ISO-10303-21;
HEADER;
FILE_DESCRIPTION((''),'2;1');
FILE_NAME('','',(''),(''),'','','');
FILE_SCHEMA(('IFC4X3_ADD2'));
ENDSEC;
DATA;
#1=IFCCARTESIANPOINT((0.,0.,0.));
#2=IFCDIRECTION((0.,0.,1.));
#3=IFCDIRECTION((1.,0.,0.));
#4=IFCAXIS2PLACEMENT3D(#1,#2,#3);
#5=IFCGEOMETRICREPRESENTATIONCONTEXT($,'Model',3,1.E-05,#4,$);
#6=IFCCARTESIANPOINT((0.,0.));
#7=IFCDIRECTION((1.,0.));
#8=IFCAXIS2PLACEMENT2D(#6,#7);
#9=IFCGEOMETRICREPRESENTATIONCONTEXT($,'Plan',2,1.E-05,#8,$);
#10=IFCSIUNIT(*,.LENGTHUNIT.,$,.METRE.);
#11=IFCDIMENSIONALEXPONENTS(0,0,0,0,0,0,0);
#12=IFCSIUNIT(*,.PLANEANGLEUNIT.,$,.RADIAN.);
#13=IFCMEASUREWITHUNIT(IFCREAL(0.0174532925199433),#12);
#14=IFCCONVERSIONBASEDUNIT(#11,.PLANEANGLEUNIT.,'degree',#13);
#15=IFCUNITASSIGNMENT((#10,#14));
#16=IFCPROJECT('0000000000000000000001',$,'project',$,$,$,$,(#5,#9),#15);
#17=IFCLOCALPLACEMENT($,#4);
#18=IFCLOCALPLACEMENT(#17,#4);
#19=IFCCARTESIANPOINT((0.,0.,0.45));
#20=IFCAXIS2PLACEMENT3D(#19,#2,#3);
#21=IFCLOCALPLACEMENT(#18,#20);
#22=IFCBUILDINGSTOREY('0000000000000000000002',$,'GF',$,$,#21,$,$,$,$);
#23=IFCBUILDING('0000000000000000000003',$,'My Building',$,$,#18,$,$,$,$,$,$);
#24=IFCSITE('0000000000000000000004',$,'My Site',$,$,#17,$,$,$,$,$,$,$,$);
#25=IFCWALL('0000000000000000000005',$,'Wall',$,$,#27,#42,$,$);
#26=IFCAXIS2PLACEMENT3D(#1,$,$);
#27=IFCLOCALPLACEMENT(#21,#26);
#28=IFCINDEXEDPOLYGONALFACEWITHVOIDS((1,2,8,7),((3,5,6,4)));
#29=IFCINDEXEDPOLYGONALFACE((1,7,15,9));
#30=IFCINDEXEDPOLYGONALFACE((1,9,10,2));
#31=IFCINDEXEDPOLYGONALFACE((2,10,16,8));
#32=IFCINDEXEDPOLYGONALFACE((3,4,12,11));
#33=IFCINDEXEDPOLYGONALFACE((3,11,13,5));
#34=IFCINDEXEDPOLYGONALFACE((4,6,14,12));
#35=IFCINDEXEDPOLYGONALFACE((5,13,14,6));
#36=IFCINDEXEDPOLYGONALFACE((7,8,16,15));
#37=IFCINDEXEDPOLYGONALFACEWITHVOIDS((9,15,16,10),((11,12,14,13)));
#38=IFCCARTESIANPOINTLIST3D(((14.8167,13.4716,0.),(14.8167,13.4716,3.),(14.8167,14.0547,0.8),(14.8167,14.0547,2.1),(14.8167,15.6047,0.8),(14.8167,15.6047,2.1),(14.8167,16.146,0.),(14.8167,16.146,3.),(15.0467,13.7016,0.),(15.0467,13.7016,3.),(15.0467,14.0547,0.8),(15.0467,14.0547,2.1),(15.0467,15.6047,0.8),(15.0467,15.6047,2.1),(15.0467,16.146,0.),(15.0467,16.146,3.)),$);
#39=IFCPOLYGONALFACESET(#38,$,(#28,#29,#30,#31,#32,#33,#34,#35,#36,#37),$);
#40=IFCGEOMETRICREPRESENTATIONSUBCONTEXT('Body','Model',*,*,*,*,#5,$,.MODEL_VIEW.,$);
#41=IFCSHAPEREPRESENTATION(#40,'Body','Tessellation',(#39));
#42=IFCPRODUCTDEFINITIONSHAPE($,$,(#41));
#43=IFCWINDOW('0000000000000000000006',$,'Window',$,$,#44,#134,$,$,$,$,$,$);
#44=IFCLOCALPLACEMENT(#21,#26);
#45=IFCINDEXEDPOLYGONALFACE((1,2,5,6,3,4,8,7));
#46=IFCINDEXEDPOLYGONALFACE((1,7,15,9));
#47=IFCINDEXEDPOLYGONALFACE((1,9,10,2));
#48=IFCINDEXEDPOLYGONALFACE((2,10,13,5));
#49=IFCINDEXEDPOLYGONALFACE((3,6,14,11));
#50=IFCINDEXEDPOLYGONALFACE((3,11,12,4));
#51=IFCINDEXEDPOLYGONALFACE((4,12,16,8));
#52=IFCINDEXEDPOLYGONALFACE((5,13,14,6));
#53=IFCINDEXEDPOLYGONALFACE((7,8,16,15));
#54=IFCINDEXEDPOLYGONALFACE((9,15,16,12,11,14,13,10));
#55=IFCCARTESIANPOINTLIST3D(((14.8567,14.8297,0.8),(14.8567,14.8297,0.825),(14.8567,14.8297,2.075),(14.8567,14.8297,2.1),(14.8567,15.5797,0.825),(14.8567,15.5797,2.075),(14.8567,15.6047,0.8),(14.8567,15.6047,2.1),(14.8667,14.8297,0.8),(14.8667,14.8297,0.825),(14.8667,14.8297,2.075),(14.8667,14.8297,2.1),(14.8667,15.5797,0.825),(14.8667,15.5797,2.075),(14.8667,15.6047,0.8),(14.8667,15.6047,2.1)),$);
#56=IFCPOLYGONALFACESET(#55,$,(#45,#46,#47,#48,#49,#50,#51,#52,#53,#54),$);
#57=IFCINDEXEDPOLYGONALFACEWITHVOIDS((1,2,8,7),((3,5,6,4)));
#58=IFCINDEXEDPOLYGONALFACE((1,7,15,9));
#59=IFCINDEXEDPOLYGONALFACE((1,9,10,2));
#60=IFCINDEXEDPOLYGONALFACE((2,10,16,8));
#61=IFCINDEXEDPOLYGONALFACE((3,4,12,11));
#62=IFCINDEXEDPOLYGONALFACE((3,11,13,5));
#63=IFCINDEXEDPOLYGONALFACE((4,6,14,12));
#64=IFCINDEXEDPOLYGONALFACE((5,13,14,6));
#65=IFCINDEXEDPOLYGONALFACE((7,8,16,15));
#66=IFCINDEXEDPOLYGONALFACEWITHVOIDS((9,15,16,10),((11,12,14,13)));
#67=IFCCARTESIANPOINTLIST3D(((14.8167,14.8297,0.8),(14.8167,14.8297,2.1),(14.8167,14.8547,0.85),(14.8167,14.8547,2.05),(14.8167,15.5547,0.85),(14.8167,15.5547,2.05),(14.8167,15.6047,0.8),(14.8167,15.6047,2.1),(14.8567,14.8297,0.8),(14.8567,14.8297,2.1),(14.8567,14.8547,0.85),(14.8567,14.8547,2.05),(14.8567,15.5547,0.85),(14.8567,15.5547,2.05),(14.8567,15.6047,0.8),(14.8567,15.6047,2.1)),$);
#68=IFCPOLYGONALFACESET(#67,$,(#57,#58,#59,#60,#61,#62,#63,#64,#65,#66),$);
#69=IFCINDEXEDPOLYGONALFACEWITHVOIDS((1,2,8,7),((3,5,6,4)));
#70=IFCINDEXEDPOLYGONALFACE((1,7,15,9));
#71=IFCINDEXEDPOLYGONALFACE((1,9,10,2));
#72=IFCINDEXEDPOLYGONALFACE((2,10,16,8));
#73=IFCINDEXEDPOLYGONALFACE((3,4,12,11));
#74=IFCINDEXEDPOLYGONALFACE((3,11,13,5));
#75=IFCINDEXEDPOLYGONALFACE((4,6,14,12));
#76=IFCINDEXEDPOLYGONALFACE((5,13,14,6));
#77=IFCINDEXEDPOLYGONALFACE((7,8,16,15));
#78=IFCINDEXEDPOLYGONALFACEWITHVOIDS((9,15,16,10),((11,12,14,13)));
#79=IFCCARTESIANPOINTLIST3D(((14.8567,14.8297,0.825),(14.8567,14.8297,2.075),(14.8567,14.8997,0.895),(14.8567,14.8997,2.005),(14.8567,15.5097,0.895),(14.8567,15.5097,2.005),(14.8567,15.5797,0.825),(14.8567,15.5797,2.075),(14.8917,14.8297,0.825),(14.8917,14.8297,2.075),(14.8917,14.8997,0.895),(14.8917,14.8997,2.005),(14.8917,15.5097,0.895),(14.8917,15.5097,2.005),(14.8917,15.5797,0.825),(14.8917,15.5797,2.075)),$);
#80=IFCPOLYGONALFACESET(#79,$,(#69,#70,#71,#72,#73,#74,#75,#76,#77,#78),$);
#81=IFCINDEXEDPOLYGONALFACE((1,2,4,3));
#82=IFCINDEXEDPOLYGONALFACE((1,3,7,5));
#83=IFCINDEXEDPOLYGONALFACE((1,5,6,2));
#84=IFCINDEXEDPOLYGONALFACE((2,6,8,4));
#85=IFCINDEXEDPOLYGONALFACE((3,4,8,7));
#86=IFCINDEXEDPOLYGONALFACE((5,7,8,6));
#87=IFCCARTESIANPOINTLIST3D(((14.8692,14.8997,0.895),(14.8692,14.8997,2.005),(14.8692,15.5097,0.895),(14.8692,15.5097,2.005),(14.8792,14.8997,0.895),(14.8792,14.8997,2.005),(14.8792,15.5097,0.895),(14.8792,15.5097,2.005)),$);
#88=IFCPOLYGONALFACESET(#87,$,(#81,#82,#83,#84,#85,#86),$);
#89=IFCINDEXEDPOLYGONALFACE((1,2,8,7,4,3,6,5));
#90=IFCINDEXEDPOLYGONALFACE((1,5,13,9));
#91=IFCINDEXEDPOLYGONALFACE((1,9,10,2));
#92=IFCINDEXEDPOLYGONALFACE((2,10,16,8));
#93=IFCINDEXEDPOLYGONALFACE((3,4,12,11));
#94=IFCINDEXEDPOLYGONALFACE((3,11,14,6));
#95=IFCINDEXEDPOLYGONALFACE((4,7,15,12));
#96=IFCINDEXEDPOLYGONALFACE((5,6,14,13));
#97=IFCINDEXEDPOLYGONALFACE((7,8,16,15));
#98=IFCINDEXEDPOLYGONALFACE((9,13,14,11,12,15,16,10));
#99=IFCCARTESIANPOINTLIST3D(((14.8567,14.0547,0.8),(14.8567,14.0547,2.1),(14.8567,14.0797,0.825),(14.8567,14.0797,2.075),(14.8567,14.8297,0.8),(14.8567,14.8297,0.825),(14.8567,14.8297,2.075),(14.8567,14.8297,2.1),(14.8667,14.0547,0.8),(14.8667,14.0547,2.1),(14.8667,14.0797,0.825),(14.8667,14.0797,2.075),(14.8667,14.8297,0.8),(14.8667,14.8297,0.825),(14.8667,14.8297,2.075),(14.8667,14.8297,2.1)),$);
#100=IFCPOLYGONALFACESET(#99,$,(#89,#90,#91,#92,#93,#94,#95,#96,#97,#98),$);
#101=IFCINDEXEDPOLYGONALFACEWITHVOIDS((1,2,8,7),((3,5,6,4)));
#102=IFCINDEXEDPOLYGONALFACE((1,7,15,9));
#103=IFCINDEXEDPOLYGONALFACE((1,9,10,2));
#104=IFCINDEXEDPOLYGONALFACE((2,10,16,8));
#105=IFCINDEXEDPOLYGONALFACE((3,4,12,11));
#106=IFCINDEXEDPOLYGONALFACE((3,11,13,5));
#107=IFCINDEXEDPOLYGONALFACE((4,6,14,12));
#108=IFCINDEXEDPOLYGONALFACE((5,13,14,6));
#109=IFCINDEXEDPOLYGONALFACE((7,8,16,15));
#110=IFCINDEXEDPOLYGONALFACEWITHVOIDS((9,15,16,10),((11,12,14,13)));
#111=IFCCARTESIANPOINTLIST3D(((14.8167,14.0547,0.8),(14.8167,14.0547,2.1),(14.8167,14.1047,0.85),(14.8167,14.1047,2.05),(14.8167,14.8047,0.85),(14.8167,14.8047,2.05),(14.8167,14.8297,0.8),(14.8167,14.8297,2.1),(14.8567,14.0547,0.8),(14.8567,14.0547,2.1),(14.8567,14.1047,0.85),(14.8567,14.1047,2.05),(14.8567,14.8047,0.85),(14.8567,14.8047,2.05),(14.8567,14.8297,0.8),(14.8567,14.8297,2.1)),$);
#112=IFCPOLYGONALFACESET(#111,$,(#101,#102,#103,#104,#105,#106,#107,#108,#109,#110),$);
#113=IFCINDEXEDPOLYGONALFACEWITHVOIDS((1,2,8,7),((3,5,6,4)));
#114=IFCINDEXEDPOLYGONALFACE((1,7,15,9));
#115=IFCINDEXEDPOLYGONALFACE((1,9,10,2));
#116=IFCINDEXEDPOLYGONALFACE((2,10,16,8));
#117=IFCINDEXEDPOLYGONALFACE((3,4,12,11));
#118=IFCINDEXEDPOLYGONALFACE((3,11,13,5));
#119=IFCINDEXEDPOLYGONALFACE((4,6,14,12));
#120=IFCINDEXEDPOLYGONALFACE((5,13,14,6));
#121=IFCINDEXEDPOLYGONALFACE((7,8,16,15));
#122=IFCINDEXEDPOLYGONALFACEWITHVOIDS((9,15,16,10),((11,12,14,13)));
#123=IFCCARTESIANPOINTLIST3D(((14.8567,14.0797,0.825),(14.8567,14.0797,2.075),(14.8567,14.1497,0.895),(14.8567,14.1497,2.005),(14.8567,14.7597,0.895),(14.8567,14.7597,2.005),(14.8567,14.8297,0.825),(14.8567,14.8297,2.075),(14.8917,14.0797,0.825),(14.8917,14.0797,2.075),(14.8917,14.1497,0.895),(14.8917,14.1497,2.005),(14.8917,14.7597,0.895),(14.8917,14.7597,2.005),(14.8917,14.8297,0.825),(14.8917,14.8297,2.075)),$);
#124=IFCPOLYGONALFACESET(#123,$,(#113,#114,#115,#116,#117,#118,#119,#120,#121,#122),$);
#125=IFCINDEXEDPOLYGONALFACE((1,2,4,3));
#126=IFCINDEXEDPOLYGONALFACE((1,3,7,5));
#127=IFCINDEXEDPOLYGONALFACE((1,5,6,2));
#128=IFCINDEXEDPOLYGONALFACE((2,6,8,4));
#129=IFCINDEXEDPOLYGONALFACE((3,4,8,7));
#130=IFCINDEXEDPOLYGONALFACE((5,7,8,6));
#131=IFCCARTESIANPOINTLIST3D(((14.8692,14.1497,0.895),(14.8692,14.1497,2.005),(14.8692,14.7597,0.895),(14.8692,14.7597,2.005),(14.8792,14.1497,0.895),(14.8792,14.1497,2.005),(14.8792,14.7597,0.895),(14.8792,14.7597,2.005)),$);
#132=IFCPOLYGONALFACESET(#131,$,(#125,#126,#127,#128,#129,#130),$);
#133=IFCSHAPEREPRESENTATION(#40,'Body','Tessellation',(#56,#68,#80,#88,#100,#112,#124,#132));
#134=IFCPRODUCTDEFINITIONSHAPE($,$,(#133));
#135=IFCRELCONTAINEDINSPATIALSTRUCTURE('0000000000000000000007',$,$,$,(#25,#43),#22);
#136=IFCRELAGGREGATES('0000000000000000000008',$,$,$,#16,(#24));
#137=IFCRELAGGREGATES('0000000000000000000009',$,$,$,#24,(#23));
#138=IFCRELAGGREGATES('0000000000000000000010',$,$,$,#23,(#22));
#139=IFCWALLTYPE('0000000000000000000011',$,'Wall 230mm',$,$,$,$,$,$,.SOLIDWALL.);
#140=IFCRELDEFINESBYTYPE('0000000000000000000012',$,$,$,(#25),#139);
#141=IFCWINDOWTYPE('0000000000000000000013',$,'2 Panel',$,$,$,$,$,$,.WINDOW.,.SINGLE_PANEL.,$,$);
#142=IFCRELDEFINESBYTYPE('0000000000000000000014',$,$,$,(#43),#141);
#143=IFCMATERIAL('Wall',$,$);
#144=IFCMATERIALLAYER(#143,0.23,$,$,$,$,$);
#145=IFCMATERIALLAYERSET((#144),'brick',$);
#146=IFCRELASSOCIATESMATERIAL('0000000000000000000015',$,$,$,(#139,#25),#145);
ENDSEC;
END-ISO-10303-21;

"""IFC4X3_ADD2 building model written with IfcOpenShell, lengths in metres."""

from ifc_helpers import new_model, entity, si_unit, converted_unit, frame, origin_with_axes, origin_2d_with_axis, place, context, subcontext, project, spatial, line, indexed_curve, outline, extrude, clip, halfspace, shape, source, transform, mapped, material, layer, layer_set, layer_usage, type_object, type_shapes, element, fill, save


model = new_model("IFC4X3_ADD2")

# Units and contexts
model_context = context("Model", 3, precision=1e-05, world=origin_with_axes())
plan_context = context("Plan", 2, precision=1e-05, world=origin_2d_with_axis())
body_context_1 = subcontext(model_context, "Body", "Model", "MODEL_VIEW")
body_context_2 = subcontext(plan_context, "Body", "Plan", "PLAN_VIEW")
ifc_project = project(units=[si_unit("LENGTHUNIT", "METRE"), converted_unit("PLANEANGLEUNIT", "degree", entity("IfcReal", 0.0174532925199433), si_unit("PLANEANGLEUNIT", "RADIAN"), dimensions=[0, 0, 0, 0, 0, 0, 0])], contexts=[model_context, plan_context])

# Site, building, storey
site_placement = place(None, origin_with_axes())
site = spatial("IfcSite", under=ifc_project, at=site_placement, Name="My Site")
building_placement = place(site_placement, origin_with_axes())
building = spatial("IfcBuilding", under=site, at=building_placement, Name="My Building")
storey_placement = place(building_placement, frame((0.0, 0.0, 0.45), z_axis=(0.0, 0.0, 1.0), x_axis=(1.0, 0.0, 0.0)))
storey = spatial("IfcBuildingStorey", under=building, at=storey_placement, Name="GF")

# Shared definitions
ifc_material_1 = material(Name="Wall")
ifc_layer = layer(ifc_material_1, 0.23)
ifc_layer_set = layer_set([ifc_layer], Name="brick")
wall_type = type_object("IfcWallType", Name="Wall 230mm", PredefinedType="SOLIDWALL", material=ifc_layer_set)

# Wall, opening, window
ifc_layer_usage_1 = layer_usage(ifc_layer_set, "AXIS2", "POSITIVE", 0.0)
wall_1_placement = place(storey_placement, frame((15.0467, 13.1463, 0.0), z_axis=(0.0, 0.0, 1.0), x_axis=(0.0, 1.0, 0.0)))
wall_1 = element("IfcWall", 1, at=wall_1_placement, inside=storey, type_object=wall_type, material=ifc_layer_usage_1, Name="Wall", context=body_context_1, shape_type="Clipping", body=[
    clip(extrude(outline(indexed_curve([(0.0, 0.0), (0.0, 0.23), (2.9997, 0.23), (2.9997, 0.0), (0.0, 0.0)], self_intersect=False)), origin_with_axes(), (0.0, 0.0, 1.0), 3.0), halfspace(frame((0.5553, 0.0, -0.45), z_axis=(-0.689998, -0.689999, 0.0), x_axis=(-0.707107, 0.707107, 0.0)), False)),
])
shared_shape_1 = source(origin_with_axes(), body_context_1, "Body", "SweptSolid", [
    extrude(outline(indexed_curve([(0.0, 0.0), (1.55, 0.0), (1.55, 1.3), (0.0, 1.3)], segments=[line(1, 2, 3, 4, 1)])), frame((0.0, -0.6, 0.0), z_axis=(0.0, -1.0, 0.0), x_axis=(1.0, 0.0, 0.0)), (0.0, 0.0, -1.0), 1.2),
])
opening_1_placement = place(wall_1_placement, frame((2.4583, 0.28, 0.8), z_axis=(0.0, 0.0, 1.0), x_axis=(-1.0, 0.0, 0.0)))
opening_1 = element("IfcOpeningElement", 2, at=opening_1_placement, cuts=wall_1, PredefinedType="OPENING", context=body_context_1, shape_type="MappedRepresentation", body=[
    mapped(shared_shape_1, transform((0.0, 0.0, 0.0), x_axis=(1.0, 0.0, 0.0), y_axis=(0.0, 1.0, 0.0), z_axis=(0.0, 0.0, 1.0), scale=1.0)),
])
window_type_1 = type_object("IfcWindowType", Name="2 Panel", PartitioningType="SINGLE_PANEL", PredefinedType="WINDOW")
shared_shape_2 = source(origin_with_axes(), body_context_1, "Body", "SweptSolid", [
    extrude(outline(indexed_curve([(0.775, 0.0), (0.0, 0.0), (0.0, 1.3), (0.775, 1.3), (0.775, 1.275), (0.025, 1.275), (0.025, 0.025), (0.775, 0.025)], segments=[line(1, 2, 3, 4, 5, 6, 7, 8, 1)])), frame((0.0, 0.09, 0.0), z_axis=(0.0, -1.0, 0.0), x_axis=(1.0, 0.0, 0.0)), (0.0, 0.0, -1.0), 0.01),
    extrude(outline(indexed_curve([(0.0, 0.0), (0.775, 0.0), (0.775, 1.3), (0.0, 1.3)], segments=[line(1, 2, 3, 4, 1)]), holes=[indexed_curve([(0.05, 0.05), (0.75, 0.05), (0.75, 1.25), (0.05, 1.25)], segments=[line(1, 2, 3, 4, 1)])]), frame((0.0, 0.05, 0.0), z_axis=(0.0, -1.0, 0.0), x_axis=(1.0, 0.0, 0.0)), (0.0, 0.0, -1.0), 0.04),
    extrude(outline(indexed_curve([(0.0, 0.0), (0.75, 0.0), (0.75, 1.25), (0.0, 1.25)], segments=[line(1, 2, 3, 4, 1)]), holes=[indexed_curve([(0.07, 0.07), (0.68, 0.07), (0.68, 1.18), (0.07, 1.18)], segments=[line(1, 2, 3, 4, 1)])]), frame((0.025, 0.09, 0.025), z_axis=(0.0, -1.0, 0.0), x_axis=(1.0, 0.0, 0.0)), (0.0, 0.0, -1.0), 0.035),
    extrude(outline(indexed_curve([(0.07, 0.07), (0.68, 0.07), (0.68, 1.18), (0.07, 1.18)], segments=[line(1, 2, 3, 4, 1)])), frame((0.025, 0.1025, 0.025), z_axis=(0.0, -1.0, 0.0), x_axis=(1.0, 0.0, 0.0)), (0.0, 0.0, -1.0), 0.01),
    extrude(outline(indexed_curve([(0.0, 1.3), (0.775, 1.3), (0.775, 0.0), (0.0, 0.0), (0.0, 0.025), (0.75, 0.025), (0.75, 1.275), (0.0, 1.275)], segments=[line(1, 2, 3, 4, 5, 6, 7, 8, 1)])), frame((0.775, 0.09, 0.0), z_axis=(0.0, -1.0, 0.0), x_axis=(1.0, 0.0, 0.0)), (0.0, 0.0, -1.0), 0.01),
    extrude(outline(indexed_curve([(0.0, 0.0), (0.775, 0.0), (0.775, 1.3), (0.0, 1.3)], segments=[line(1, 2, 3, 4, 1)]), holes=[indexed_curve([(0.025, 0.05), (0.725, 0.05), (0.725, 1.25), (0.025, 1.25)], segments=[line(1, 2, 3, 4, 1)])]), frame((0.775, 0.05, 0.0), z_axis=(0.0, -1.0, 0.0), x_axis=(1.0, 0.0, 0.0)), (0.0, 0.0, -1.0), 0.04),
    extrude(outline(indexed_curve([(0.0, 0.0), (0.75, 0.0), (0.75, 1.25), (0.0, 1.25)], segments=[line(1, 2, 3, 4, 1)]), holes=[indexed_curve([(0.07, 0.07), (0.68, 0.07), (0.68, 1.18), (0.07, 1.18)], segments=[line(1, 2, 3, 4, 1)])]), frame((0.775, 0.09, 0.025), z_axis=(0.0, -1.0, 0.0), x_axis=(1.0, 0.0, 0.0)), (0.0, 0.0, -1.0), 0.035),
    extrude(outline(indexed_curve([(0.07, 0.07), (0.68, 0.07), (0.68, 1.18), (0.07, 1.18)], segments=[line(1, 2, 3, 4, 1)])), frame((0.775, 0.1025, 0.025), z_axis=(0.0, -1.0, 0.0), x_axis=(1.0, 0.0, 0.0)), (0.0, 0.0, -1.0), 0.01),
])
shared_shape_3 = source(origin_with_axes(), body_context_2, "Body", "Curve2D", [
    entity("IfcIndexedPolyCurve", entity("IfcCartesianPointList2D", [[0.05, 0.05], [0.75, 0.05]])),
    entity("IfcIndexedPolyCurve", entity("IfcCartesianPointList2D", [[0.0, 0.1], [0.025, 0.1], [0.025, 0.09], [0.05, 0.09], [0.05, 0.05], [0.0, 0.05]]), [entity("IfcLineIndex", [1, 2, 3, 4, 5, 6, 1])]),
    entity("IfcIndexedPolyCurve", entity("IfcCartesianPointList2D", [[0.775, 0.1], [0.775, 0.1], [0.775, 0.09], [0.75, 0.09], [0.75, 0.05], [0.775, 0.05]])),
    entity("IfcIndexedPolyCurve", entity("IfcCartesianPointList2D", [[0.025, 0.09], [0.095, 0.09], [0.095, 0.125], [0.025, 0.125]]), [entity("IfcLineIndex", [1, 2, 3, 4, 1])]),
    entity("IfcIndexedPolyCurve", entity("IfcCartesianPointList2D", [[0.775, 0.09], [0.705, 0.09], [0.705, 0.125], [0.775, 0.125]]), [entity("IfcLineIndex", [1, 2, 3, 4, 1])]),
    entity("IfcIndexedPolyCurve", entity("IfcCartesianPointList2D", [[0.095, 0.09], [0.705, 0.09]])),
    entity("IfcIndexedPolyCurve", entity("IfcCartesianPointList2D", [[0.095, 0.125], [0.705, 0.125]])),
    entity("IfcIndexedPolyCurve", entity("IfcCartesianPointList2D", [[0.095, 0.1075], [0.705, 0.1075]])),
    entity("IfcIndexedPolyCurve", entity("IfcCartesianPointList2D", [[0.8, 0.05], [1.5, 0.05]])),
    entity("IfcIndexedPolyCurve", entity("IfcCartesianPointList2D", [[0.775, 0.1], [0.775, 0.1], [0.775, 0.09], [0.8, 0.09], [0.8, 0.05], [0.775, 0.05]])),
    entity("IfcIndexedPolyCurve", entity("IfcCartesianPointList2D", [[1.55, 0.1], [1.525, 0.1], [1.525, 0.09], [1.5, 0.09], [1.5, 0.05], [1.55, 0.05]]), [entity("IfcLineIndex", [1, 2, 3, 4, 5, 6, 1])]),
    entity("IfcIndexedPolyCurve", entity("IfcCartesianPointList2D", [[0.775, 0.09], [0.845, 0.09], [0.845, 0.125], [0.775, 0.125]]), [entity("IfcLineIndex", [1, 2, 3, 4, 1])]),
    entity("IfcIndexedPolyCurve", entity("IfcCartesianPointList2D", [[1.525, 0.09], [1.455, 0.09], [1.455, 0.125], [1.525, 0.125]]), [entity("IfcLineIndex", [1, 2, 3, 4, 1])]),
    entity("IfcIndexedPolyCurve", entity("IfcCartesianPointList2D", [[0.845, 0.09], [1.455, 0.09]])),
    entity("IfcIndexedPolyCurve", entity("IfcCartesianPointList2D", [[0.845, 0.125], [1.455, 0.125]])),
    entity("IfcIndexedPolyCurve", entity("IfcCartesianPointList2D", [[0.845, 0.1075], [1.455, 0.1075]])),
])
type_shapes(window_type_1, [shared_shape_2, shared_shape_3])
window_1_placement = place(opening_1_placement, frame((0.0, 0.0, 0.0), z_axis=(0.0, 0.0, 1.0), x_axis=(1.0, 0.0, 0.0)))
window_1 = element("IfcWindow", 3, at=window_1_placement, inside=storey, type_object=window_type_1, Name="Window", shapes=[
    shape(body_context_1, "Body", "MappedRepresentation", [mapped(shared_shape_2, transform((0.0, 0.0, 0.0), x_axis=(1.0, 0.0, 0.0), y_axis=(0.0, 1.0, 0.0), z_axis=(0.0, 0.0, 1.0), scale=1.0))]),
    shape(body_context_2, "Body", "MappedRepresentation", [mapped(shared_shape_3, transform((0.0, 0.0, 0.0), x_axis=(1.0, 0.0, 0.0), y_axis=(0.0, 1.0, 0.0), z_axis=(0.0, 0.0, 1.0), scale=1.0))]),
])
fill(opening_1, window_1)

save(model, "model.ifc")
